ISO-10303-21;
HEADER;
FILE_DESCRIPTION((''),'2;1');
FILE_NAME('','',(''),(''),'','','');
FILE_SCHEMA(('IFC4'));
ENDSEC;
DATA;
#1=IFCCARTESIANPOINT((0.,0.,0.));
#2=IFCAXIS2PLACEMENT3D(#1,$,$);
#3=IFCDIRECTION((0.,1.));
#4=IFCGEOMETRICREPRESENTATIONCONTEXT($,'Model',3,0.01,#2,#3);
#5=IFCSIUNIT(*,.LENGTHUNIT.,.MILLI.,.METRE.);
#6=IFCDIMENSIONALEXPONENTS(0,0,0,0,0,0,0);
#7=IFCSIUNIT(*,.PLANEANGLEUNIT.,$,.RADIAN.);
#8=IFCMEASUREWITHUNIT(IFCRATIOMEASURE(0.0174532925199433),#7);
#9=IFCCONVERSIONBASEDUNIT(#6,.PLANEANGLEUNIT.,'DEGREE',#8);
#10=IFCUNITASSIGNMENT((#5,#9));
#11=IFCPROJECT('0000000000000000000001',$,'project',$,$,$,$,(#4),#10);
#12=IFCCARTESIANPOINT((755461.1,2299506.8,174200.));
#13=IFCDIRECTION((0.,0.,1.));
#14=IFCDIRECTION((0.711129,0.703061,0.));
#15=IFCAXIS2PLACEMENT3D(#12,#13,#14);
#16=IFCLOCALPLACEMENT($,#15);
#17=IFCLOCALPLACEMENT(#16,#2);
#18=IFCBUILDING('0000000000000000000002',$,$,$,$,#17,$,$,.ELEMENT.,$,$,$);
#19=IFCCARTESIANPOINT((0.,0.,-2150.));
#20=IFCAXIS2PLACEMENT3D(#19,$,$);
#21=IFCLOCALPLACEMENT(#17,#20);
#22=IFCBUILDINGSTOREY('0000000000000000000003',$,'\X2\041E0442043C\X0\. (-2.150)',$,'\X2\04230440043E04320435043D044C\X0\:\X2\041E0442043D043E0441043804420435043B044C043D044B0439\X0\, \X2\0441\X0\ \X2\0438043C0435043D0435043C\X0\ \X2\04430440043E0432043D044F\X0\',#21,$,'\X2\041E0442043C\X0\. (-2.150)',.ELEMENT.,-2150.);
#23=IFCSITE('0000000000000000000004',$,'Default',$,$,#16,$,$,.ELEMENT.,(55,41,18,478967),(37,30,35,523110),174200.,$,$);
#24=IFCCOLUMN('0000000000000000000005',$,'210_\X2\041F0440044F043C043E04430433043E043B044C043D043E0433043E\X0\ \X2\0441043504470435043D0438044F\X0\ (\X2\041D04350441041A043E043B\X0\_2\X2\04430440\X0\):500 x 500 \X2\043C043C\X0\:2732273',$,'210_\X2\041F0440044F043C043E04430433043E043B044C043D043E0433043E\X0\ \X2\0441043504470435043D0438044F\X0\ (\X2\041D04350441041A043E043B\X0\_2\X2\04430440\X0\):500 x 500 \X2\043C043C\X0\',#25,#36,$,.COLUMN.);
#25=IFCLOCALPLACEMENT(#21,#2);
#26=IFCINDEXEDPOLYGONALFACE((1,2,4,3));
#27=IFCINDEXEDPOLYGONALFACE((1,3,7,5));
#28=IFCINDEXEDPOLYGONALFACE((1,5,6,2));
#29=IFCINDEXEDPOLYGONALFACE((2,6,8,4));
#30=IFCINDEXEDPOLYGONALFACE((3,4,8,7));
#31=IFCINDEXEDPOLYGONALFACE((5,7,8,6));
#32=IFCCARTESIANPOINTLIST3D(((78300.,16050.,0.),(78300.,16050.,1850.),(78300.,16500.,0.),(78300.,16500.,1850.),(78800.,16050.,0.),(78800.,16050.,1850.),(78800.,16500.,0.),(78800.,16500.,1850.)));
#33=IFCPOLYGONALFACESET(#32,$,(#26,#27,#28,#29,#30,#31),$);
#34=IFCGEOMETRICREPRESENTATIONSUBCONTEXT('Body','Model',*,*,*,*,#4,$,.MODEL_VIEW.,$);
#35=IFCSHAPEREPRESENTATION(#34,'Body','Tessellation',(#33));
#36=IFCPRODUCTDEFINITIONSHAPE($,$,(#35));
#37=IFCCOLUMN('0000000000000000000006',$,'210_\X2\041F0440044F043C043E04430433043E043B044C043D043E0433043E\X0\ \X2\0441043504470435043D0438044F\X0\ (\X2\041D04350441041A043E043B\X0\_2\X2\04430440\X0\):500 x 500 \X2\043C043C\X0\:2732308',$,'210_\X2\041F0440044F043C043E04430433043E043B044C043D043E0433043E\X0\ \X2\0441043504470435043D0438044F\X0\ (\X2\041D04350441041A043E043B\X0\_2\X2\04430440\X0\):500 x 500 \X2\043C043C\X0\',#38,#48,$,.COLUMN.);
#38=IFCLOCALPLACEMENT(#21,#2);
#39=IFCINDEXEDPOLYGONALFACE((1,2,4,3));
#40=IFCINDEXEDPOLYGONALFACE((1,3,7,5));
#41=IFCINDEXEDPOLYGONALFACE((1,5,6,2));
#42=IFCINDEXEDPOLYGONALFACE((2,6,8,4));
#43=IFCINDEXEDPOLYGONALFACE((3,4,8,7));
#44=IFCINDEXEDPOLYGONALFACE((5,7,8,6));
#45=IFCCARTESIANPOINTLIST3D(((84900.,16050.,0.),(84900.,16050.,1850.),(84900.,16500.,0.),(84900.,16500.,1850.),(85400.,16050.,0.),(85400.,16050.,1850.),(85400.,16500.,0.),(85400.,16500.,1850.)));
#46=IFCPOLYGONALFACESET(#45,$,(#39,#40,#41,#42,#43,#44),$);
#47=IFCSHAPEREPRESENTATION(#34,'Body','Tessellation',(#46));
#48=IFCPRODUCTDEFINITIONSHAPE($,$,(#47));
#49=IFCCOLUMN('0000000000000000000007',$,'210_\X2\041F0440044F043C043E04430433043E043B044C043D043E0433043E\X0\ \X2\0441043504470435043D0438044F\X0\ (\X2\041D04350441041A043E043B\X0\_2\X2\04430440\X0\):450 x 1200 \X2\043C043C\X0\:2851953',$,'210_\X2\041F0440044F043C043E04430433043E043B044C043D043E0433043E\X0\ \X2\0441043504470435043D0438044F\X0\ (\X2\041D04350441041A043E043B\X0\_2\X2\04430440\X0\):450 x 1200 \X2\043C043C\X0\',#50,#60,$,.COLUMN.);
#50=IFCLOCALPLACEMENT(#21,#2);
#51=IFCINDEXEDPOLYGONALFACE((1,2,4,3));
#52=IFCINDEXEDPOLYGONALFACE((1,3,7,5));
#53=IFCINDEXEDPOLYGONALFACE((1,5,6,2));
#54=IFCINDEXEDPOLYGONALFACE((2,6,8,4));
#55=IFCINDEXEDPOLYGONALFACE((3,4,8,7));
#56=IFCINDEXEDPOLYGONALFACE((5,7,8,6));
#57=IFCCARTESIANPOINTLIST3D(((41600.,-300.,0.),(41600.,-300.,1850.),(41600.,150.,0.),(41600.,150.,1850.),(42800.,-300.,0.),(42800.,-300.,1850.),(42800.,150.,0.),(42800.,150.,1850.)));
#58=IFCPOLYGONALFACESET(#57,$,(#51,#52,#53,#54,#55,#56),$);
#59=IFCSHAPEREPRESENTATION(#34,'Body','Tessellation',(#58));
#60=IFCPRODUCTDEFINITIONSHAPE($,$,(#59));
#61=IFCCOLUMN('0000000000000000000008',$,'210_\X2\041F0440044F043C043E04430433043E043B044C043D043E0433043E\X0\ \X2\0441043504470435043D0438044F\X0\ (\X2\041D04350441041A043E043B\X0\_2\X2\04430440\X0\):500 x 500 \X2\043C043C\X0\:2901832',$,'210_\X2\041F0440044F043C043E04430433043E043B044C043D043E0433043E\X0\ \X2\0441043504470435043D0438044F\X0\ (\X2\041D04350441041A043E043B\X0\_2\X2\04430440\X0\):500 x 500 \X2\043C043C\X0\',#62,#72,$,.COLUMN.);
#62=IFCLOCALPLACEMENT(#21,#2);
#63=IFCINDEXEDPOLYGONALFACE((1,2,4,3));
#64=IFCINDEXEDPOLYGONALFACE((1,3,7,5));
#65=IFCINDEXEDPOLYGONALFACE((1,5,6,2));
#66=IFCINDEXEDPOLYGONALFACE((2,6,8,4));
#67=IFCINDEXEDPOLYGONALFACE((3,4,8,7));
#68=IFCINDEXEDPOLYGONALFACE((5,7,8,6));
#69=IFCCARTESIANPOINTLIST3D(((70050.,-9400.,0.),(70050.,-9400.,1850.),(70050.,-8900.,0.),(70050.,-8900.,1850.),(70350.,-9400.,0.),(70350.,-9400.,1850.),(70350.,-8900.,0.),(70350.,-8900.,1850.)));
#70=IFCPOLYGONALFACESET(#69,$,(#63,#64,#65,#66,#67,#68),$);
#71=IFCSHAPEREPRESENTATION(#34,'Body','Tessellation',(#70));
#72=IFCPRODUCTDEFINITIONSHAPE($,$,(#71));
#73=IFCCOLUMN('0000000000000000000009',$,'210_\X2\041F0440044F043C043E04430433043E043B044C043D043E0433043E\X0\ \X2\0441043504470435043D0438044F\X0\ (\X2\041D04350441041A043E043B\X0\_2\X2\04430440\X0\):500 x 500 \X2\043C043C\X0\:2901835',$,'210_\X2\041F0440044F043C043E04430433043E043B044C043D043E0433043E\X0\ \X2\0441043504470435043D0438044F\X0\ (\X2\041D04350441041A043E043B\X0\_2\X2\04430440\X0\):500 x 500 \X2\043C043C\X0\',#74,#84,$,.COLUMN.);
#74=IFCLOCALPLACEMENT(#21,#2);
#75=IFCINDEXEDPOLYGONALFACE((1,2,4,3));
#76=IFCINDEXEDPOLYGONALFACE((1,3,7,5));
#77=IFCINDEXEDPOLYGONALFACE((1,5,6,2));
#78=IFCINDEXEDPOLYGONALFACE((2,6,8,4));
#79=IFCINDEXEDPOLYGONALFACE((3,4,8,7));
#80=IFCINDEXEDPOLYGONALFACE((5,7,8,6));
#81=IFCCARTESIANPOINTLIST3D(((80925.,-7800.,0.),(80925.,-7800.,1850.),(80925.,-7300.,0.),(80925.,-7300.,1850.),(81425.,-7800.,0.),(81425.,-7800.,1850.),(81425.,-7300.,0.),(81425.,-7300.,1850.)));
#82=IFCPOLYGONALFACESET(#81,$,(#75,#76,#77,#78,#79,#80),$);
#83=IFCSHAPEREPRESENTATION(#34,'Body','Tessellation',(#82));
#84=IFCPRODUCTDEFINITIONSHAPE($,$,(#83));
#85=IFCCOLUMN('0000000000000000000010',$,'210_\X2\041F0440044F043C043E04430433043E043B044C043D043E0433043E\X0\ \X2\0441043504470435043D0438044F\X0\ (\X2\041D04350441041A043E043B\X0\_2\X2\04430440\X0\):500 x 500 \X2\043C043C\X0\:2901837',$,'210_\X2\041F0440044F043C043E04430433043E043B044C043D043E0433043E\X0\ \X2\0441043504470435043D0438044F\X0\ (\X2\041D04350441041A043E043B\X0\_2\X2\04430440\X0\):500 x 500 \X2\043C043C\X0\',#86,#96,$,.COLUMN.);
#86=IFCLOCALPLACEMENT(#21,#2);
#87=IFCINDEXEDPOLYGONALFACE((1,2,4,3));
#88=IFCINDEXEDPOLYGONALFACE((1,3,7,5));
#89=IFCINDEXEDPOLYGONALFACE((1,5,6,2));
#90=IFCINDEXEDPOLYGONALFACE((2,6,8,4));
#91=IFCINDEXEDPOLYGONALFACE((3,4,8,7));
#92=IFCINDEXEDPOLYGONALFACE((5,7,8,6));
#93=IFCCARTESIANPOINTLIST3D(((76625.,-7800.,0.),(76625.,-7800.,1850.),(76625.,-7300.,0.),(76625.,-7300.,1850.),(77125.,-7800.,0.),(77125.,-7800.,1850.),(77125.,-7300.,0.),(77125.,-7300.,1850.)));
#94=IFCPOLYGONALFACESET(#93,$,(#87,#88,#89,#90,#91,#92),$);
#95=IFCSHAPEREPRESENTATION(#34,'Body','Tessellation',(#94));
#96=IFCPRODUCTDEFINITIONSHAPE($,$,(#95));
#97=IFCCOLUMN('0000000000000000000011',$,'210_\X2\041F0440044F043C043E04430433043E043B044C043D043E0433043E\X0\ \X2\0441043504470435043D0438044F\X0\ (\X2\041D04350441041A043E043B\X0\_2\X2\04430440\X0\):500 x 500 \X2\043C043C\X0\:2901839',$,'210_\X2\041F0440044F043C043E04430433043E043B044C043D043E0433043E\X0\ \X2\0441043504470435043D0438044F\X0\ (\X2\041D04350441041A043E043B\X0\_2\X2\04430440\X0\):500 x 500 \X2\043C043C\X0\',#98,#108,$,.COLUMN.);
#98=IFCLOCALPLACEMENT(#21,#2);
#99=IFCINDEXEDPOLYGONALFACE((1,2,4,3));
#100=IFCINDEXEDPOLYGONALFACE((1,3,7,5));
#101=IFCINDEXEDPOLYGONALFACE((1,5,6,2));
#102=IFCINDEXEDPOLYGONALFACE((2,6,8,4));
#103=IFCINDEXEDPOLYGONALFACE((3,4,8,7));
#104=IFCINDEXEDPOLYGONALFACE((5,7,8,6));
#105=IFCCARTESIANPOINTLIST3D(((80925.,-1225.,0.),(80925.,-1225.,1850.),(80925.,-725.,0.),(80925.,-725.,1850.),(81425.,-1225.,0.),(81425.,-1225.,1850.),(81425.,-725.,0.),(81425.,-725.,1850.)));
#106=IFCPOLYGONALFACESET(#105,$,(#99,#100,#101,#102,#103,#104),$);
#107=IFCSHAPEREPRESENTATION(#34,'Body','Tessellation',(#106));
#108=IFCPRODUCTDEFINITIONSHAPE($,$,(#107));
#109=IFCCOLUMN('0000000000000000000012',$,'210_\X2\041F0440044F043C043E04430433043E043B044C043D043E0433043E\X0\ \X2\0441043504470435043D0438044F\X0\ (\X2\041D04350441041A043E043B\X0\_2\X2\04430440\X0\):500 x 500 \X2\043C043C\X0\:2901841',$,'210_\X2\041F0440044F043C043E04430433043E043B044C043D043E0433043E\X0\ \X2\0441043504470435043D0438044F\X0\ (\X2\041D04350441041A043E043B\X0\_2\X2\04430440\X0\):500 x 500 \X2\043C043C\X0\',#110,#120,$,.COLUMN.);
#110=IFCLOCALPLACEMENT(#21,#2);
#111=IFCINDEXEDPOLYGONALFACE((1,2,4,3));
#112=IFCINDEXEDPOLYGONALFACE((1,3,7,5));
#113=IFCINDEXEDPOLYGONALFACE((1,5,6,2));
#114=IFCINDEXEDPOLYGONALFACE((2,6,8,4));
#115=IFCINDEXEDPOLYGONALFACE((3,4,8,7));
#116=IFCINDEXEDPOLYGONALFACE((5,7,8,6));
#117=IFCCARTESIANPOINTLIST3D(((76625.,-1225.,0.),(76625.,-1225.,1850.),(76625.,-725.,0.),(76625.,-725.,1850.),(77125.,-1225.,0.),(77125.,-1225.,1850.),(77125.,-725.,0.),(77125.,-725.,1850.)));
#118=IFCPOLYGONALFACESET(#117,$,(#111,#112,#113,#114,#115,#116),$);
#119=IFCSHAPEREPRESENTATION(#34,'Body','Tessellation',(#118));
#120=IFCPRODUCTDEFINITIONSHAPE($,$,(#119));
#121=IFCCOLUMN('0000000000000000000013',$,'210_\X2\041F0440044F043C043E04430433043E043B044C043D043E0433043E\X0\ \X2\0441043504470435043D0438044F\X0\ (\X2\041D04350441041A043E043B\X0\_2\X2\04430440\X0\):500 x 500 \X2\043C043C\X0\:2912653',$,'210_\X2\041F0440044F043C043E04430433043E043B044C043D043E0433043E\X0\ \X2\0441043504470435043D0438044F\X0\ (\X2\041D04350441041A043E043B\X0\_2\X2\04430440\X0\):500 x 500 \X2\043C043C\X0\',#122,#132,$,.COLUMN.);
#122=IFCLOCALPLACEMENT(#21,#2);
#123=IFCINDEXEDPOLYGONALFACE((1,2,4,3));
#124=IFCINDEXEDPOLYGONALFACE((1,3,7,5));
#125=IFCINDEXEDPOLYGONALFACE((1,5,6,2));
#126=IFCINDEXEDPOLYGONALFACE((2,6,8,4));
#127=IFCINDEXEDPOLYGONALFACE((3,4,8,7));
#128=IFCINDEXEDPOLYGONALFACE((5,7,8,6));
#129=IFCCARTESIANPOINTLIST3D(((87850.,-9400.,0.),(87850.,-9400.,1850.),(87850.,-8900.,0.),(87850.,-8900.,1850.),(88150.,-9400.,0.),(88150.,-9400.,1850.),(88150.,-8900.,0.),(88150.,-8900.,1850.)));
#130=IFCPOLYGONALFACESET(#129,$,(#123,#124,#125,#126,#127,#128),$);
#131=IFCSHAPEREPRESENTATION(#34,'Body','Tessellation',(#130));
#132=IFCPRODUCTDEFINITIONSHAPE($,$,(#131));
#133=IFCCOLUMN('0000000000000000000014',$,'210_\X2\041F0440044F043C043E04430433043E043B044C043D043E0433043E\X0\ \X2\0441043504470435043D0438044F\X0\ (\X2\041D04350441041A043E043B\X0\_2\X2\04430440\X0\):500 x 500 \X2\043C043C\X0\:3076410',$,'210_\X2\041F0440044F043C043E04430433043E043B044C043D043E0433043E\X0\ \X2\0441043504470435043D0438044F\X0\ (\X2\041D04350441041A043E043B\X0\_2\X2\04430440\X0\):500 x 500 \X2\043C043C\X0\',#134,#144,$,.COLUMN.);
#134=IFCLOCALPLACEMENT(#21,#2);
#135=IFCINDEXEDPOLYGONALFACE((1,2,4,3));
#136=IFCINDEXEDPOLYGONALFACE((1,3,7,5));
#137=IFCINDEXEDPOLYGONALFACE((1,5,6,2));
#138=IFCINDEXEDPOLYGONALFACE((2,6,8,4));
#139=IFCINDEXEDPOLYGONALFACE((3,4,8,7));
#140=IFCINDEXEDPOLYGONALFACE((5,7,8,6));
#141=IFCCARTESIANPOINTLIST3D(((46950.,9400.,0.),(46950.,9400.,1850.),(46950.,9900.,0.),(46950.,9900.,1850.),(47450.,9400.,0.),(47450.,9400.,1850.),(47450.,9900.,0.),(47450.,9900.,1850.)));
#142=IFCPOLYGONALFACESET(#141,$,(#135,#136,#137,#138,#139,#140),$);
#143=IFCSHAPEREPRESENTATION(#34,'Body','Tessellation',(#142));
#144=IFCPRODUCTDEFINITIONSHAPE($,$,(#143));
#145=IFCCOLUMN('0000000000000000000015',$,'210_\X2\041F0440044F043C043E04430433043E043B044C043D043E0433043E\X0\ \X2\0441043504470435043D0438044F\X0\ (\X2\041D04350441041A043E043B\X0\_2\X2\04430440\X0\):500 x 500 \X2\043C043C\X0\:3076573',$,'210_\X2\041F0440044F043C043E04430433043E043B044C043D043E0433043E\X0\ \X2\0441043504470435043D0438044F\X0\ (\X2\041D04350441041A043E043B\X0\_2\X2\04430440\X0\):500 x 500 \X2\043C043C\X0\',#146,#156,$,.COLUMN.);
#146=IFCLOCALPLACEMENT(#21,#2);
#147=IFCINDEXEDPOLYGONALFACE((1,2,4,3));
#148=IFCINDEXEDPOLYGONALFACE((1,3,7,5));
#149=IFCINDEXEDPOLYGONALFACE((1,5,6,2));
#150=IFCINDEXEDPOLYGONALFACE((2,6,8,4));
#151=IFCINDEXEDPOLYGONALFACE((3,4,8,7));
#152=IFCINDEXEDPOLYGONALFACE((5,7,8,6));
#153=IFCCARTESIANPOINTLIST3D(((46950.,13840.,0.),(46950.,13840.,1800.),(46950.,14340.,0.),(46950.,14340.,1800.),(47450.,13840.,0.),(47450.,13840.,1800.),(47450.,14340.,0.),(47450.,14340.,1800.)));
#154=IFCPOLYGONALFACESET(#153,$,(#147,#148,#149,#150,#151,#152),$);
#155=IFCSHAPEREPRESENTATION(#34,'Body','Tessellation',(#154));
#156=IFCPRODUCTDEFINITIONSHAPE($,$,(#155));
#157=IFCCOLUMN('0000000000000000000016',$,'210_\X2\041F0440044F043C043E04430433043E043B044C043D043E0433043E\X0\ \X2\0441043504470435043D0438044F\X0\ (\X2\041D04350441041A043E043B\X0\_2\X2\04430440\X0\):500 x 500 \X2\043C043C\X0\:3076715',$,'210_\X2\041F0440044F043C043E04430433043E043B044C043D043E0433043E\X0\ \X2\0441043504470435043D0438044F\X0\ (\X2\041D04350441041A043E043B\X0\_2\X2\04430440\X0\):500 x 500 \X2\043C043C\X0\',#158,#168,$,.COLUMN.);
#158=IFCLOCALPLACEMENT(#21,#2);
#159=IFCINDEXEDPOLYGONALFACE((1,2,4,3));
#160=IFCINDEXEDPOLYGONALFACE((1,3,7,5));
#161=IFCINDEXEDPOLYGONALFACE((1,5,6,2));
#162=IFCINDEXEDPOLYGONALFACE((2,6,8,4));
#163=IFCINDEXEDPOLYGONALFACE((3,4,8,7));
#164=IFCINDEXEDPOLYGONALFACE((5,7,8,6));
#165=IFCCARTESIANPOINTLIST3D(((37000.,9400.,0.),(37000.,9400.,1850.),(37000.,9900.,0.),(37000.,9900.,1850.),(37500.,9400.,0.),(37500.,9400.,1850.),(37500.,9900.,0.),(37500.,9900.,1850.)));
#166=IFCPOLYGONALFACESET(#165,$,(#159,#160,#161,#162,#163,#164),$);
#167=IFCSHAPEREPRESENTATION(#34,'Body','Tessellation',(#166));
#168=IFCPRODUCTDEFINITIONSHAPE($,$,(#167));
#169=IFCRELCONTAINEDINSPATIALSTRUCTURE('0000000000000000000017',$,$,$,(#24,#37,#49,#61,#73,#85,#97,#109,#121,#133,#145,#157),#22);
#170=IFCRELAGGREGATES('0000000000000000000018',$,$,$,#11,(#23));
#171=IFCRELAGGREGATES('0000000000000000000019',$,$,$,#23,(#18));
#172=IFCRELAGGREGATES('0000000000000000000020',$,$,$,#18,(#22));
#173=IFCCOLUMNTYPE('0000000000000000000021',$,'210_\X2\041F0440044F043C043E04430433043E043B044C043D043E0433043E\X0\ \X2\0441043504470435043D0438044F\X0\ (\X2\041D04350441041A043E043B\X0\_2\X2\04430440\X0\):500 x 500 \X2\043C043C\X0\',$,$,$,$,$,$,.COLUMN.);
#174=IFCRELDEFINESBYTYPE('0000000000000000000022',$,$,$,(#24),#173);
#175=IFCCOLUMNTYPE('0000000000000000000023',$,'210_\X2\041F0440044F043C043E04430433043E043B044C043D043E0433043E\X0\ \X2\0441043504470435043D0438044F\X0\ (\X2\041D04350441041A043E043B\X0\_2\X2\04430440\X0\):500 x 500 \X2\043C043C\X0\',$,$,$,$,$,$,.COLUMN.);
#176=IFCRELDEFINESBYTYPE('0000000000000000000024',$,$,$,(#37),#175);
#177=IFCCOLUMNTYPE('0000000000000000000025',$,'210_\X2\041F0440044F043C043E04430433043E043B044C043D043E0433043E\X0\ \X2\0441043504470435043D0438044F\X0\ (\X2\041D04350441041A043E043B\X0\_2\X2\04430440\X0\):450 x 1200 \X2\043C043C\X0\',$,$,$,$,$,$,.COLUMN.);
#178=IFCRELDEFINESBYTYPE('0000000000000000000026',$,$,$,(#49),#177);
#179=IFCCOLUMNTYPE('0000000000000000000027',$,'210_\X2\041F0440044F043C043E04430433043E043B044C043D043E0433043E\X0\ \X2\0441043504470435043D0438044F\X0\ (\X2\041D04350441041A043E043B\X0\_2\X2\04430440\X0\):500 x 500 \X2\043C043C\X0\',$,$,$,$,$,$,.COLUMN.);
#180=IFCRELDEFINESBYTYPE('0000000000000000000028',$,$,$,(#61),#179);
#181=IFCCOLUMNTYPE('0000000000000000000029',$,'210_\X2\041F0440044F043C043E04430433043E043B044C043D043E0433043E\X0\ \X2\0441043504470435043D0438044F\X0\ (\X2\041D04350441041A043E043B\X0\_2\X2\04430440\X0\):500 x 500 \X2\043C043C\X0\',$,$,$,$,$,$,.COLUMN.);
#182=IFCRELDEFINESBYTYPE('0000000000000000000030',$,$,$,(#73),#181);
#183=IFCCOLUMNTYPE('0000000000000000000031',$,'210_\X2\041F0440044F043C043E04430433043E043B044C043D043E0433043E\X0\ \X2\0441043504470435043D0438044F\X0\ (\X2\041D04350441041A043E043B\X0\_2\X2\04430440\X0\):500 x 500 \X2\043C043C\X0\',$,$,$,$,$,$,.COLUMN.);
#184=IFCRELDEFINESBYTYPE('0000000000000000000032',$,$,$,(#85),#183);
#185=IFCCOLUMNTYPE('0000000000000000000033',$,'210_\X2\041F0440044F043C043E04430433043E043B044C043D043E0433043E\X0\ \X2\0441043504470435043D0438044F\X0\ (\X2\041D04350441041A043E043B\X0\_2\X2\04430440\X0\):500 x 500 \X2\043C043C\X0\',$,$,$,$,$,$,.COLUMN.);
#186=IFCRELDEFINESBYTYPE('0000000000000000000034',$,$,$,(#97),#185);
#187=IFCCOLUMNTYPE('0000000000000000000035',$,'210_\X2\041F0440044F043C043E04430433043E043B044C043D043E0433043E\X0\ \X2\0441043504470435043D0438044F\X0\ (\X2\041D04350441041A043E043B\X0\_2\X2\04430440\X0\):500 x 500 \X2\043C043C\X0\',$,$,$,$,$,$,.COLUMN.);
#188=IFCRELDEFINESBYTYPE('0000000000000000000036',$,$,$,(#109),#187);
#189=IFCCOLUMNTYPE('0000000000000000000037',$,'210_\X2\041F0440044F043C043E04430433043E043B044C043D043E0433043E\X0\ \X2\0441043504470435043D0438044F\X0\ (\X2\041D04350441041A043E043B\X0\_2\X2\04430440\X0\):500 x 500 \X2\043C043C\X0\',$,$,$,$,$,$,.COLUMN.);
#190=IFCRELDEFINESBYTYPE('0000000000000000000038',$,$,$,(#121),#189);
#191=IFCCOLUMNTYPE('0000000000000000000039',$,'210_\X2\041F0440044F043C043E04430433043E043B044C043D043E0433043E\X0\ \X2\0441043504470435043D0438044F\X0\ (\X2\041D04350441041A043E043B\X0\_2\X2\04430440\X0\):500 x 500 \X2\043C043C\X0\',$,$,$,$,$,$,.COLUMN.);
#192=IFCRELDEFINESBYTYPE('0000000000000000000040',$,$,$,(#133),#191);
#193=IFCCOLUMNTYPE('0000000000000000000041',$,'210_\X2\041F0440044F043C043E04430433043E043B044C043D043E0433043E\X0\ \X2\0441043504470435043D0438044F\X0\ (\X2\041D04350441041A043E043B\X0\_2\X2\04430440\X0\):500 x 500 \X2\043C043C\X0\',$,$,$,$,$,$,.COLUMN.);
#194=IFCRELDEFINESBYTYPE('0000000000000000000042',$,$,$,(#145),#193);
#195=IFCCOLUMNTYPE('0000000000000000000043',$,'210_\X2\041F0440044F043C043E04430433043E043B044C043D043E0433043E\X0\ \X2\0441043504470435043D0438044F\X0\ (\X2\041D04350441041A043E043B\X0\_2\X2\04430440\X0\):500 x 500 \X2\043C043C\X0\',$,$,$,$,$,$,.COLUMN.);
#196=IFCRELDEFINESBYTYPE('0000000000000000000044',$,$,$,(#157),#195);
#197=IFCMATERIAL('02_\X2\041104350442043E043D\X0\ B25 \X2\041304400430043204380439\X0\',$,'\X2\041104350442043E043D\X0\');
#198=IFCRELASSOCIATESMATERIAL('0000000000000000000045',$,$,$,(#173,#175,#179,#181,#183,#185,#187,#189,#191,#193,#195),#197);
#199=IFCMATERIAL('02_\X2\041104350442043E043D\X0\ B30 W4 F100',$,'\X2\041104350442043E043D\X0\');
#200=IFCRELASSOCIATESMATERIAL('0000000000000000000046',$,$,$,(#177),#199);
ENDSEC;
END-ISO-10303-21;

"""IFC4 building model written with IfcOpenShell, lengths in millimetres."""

from ifc_helpers import new_model, entity, si_unit, converted_unit, direction, frame, origin, place, context, subcontext, project, spatial, indexed_curve, outline, extrude, source, transform, mapped, material, type_object, type_shapes, element, save


model = new_model("IFC4")

# Units and contexts
model_context = context("Model", 3, precision=0.01, world=origin(), true_north=direction((0.0, 1.0)))
body_context = subcontext(model_context, "Body", "Model", "MODEL_VIEW")
ifc_project = project(units=[si_unit("LENGTHUNIT", "METRE", prefix="MILLI"), converted_unit("PLANEANGLEUNIT", "DEGREE", entity("IfcRatioMeasure", 0.0174532925199433), si_unit("PLANEANGLEUNIT", "RADIAN"), dimensions=[0, 0, 0, 0, 0, 0, 0])], contexts=[model_context])

# Site, building, storey
site_placement = place(None, frame((755461.1, 2299506.8, 174200.0), z_axis=(0.0, 0.0, 1.0), x_axis=(0.711129, 0.703061, 0.0)))
site = spatial("IfcSite", under=ifc_project, at=site_placement, Name="Default", CompositionType="ELEMENT", RefLatitude=(55, 41, 18, 478967), RefLongitude=(37, 30, 35, 523110), RefElevation=174200.0)
building_placement = place(site_placement, origin())
building = spatial("IfcBuilding", under=site, at=building_placement, CompositionType="ELEMENT")
storey_placement = place(building_placement, frame((0.0, 0.0, -2150.0)))
storey = spatial("IfcBuildingStorey", under=building, at=storey_placement, Name="Отм. (-2.150)", ObjectType="Уровень:Относительный, с именем уровня", LongName="Отм. (-2.150)", CompositionType="ELEMENT", Elevation=-2150.0)

# Columns
ifc_material_1 = material(Name="02_Бетон B25 Гравий", Category="Бетон")
column_type_1 = type_object("IfcColumnType", Name="210_Прямоугольного сечения (НесКол_2ур):500 x 500 мм", PredefinedType="COLUMN", material=ifc_material_1)
shared_shape_1 = source(origin(), body_context, "Body", "SweptSolid", [
    extrude(outline(indexed_curve([(-225.0, -250.0), (225.0, -250.0), (225.0, 250.0), (-225.0, 250.0), (-225.0, -250.0)], self_intersect=False)), frame((78550.0, 16275.0, -2150.0), z_axis=(0.0, 0.0, 1.0), x_axis=(0.0, -1.0, 0.0)), (0.0, 0.0, 1.0), 1850.0),
])
type_shapes(column_type_1, [shared_shape_1])
column_1_placement = place(storey_placement, frame((0.0, 0.0, 2150.0)))
element("IfcColumn", 1, at=column_1_placement, inside=storey, type_object=column_type_1, Name="210_Прямоугольного сечения (НесКол_2ур):500 x 500 мм:2732273", ObjectType="210_Прямоугольного сечения (НесКол_2ур):500 x 500 мм", PredefinedType="COLUMN", context=body_context, shape_type="MappedRepresentation", body=[
    mapped(shared_shape_1, transform((0.0, 0.0, 0.0), scale=1.0)),
])
column_type_2 = type_object("IfcColumnType", Name="210_Прямоугольного сечения (НесКол_2ур):500 x 500 мм", PredefinedType="COLUMN", material=ifc_material_1)
shared_shape_2 = source(origin(), body_context, "Body", "SweptSolid", [
    extrude(outline(indexed_curve([(-225.0, -250.0), (225.0, -250.0), (225.0, 250.0), (-225.0, 250.0), (-225.0, -250.0)], self_intersect=False)), frame((85150.0, 16275.0, -2150.0), z_axis=(0.0, 0.0, 1.0), x_axis=(0.0, -1.0, 0.0)), (0.0, 0.0, 1.0), 1850.0),
])
type_shapes(column_type_2, [shared_shape_2])
column_2_placement = place(storey_placement, frame((0.0, 0.0, 2150.0)))
element("IfcColumn", 2, at=column_2_placement, inside=storey, type_object=column_type_2, Name="210_Прямоугольного сечения (НесКол_2ур):500 x 500 мм:2732308", ObjectType="210_Прямоугольного сечения (НесКол_2ур):500 x 500 мм", PredefinedType="COLUMN", context=body_context, shape_type="MappedRepresentation", body=[
    mapped(shared_shape_2, transform((0.0, 0.0, 0.0), scale=1.0)),
])
ifc_material_2 = material(Name="02_Бетон B30 W4 F100", Category="Бетон")
column_type_3 = type_object("IfcColumnType", Name="210_Прямоугольного сечения (НесКол_2ур):450 x 1200 мм", PredefinedType="COLUMN", material=ifc_material_2)
shared_shape_3 = source(origin(), body_context, "Body", "SweptSolid", [
    extrude(outline(indexed_curve([(-225.0, -600.0), (225.0, -600.0), (225.0, 600.0), (-225.0, 600.0), (-225.0, -600.0)], self_intersect=False)), frame((42200.0, -75.0, -2150.0), z_axis=(0.0, 0.0, 1.0), x_axis=(0.0, -1.0, 0.0)), (0.0, 0.0, 1.0), 1850.0),
])
type_shapes(column_type_3, [shared_shape_3])
column_3_placement = place(storey_placement, frame((0.0, 0.0, 2150.0)))
element("IfcColumn", 3, at=column_3_placement, inside=storey, type_object=column_type_3, Name="210_Прямоугольного сечения (НесКол_2ур):450 x 1200 мм:2851953", ObjectType="210_Прямоугольного сечения (НесКол_2ур):450 x 1200 мм", PredefinedType="COLUMN", context=body_context, shape_type="MappedRepresentation", body=[
    mapped(shared_shape_3, transform((0.0, 0.0, 0.0), scale=1.0)),
])
column_type_4 = type_object("IfcColumnType", Name="210_Прямоугольного сечения (НесКол_2ур):500 x 500 мм", PredefinedType="COLUMN", material=ifc_material_1)
shared_shape_4 = source(origin(), body_context, "Body", "SweptSolid", [
    extrude(outline(indexed_curve([(-250.0, -150.0), (250.0, -150.0), (250.0, 150.0), (-250.0, 150.0), (-250.0, -150.0)], self_intersect=False)), frame((70200.0, -9150.0, -2150.0), z_axis=(0.0, 0.0, 1.0), x_axis=(0.0, -1.0, 0.0)), (0.0, 0.0, 1.0), 1850.0),
])
type_shapes(column_type_4, [shared_shape_4])
column_4_placement = place(storey_placement, frame((0.0, 0.0, 2150.0)))
element("IfcColumn", 4, at=column_4_placement, inside=storey, type_object=column_type_4, Name="210_Прямоугольного сечения (НесКол_2ур):500 x 500 мм:2901832", ObjectType="210_Прямоугольного сечения (НесКол_2ур):500 x 500 мм", PredefinedType="COLUMN", context=body_context, shape_type="MappedRepresentation", body=[
    mapped(shared_shape_4, transform((0.0, 0.0, 0.0), scale=1.0)),
])
column_type_5 = type_object("IfcColumnType", Name="210_Прямоугольного сечения (НесКол_2ур):500 x 500 мм", PredefinedType="COLUMN", material=ifc_material_1)
shared_shape_5 = source(origin(), body_context, "Body", "SweptSolid", [
    extrude(outline(indexed_curve([(-250.0, -250.0), (250.0, -250.0), (250.0, 250.0), (-250.0, 250.0), (-250.0, -250.0)], self_intersect=False)), frame((81175.0, -7550.0, -2150.0), z_axis=(0.0, 0.0, 1.0), x_axis=(0.0, -1.0, 0.0)), (0.0, 0.0, 1.0), 1850.0),
])
type_shapes(column_type_5, [shared_shape_5])
column_5_placement = place(storey_placement, frame((0.0, 0.0, 2150.0)))
element("IfcColumn", 5, at=column_5_placement, inside=storey, type_object=column_type_5, Name="210_Прямоугольного сечения (НесКол_2ур):500 x 500 мм:2901835", ObjectType="210_Прямоугольного сечения (НесКол_2ур):500 x 500 мм", PredefinedType="COLUMN", context=body_context, shape_type="MappedRepresentation", body=[
    mapped(shared_shape_5, transform((0.0, 0.0, 0.0), scale=1.0)),
])
column_type_6 = type_object("IfcColumnType", Name="210_Прямоугольного сечения (НесКол_2ур):500 x 500 мм", PredefinedType="COLUMN", material=ifc_material_1)
shared_shape_6 = source(origin(), body_context, "Body", "SweptSolid", [
    extrude(outline(indexed_curve([(-250.0, -250.0), (250.0, -250.0), (250.0, 250.0), (-250.0, 250.0), (-250.0, -250.0)], self_intersect=False)), frame((76875.0, -7550.0, -2150.0), z_axis=(0.0, 0.0, 1.0), x_axis=(0.0, -1.0, 0.0)), (0.0, 0.0, 1.0), 1850.0),
])
type_shapes(column_type_6, [shared_shape_6])
column_6_placement = place(storey_placement, frame((0.0, 0.0, 2150.0)))
element("IfcColumn", 6, at=column_6_placement, inside=storey, type_object=column_type_6, Name="210_Прямоугольного сечения (НесКол_2ур):500 x 500 мм:2901837", ObjectType="210_Прямоугольного сечения (НесКол_2ур):500 x 500 мм", PredefinedType="COLUMN", context=body_context, shape_type="MappedRepresentation", body=[
    mapped(shared_shape_6, transform((0.0, 0.0, 0.0), scale=1.0)),
])
column_type_7 = type_object("IfcColumnType", Name="210_Прямоугольного сечения (НесКол_2ур):500 x 500 мм", PredefinedType="COLUMN", material=ifc_material_1)
shared_shape_7 = source(origin(), body_context, "Body", "SweptSolid", [
    extrude(outline(indexed_curve([(-250.0, -250.0), (250.0, -250.0), (250.0, 250.0), (-250.0, 250.0), (-250.0, -250.0)], self_intersect=False)), frame((81175.0, -975.0, -2150.0), z_axis=(0.0, 0.0, 1.0), x_axis=(0.0, -1.0, 0.0)), (0.0, 0.0, 1.0), 1850.0),
])
type_shapes(column_type_7, [shared_shape_7])
column_7_placement = place(storey_placement, frame((0.0, 0.0, 2150.0)))
element("IfcColumn", 7, at=column_7_placement, inside=storey, type_object=column_type_7, Name="210_Прямоугольного сечения (НесКол_2ур):500 x 500 мм:2901839", ObjectType="210_Прямоугольного сечения (НесКол_2ур):500 x 500 мм", PredefinedType="COLUMN", context=body_context, shape_type="MappedRepresentation", body=[
    mapped(shared_shape_7, transform((0.0, 0.0, 0.0), scale=1.0)),
])
column_type_8 = type_object("IfcColumnType", Name="210_Прямоугольного сечения (НесКол_2ур):500 x 500 мм", PredefinedType="COLUMN", material=ifc_material_1)
shared_shape_8 = source(origin(), body_context, "Body", "SweptSolid", [
    extrude(outline(indexed_curve([(-250.0, -250.0), (250.0, -250.0), (250.0, 250.0), (-250.0, 250.0), (-250.0, -250.0)], self_intersect=False)), frame((76875.0, -975.0, -2150.0), z_axis=(0.0, 0.0, 1.0), x_axis=(0.0, -1.0, 0.0)), (0.0, 0.0, 1.0), 1850.0),
])
type_shapes(column_type_8, [shared_shape_8])
column_8_placement = place(storey_placement, frame((0.0, 0.0, 2150.0)))
element("IfcColumn", 8, at=column_8_placement, inside=storey, type_object=column_type_8, Name="210_Прямоугольного сечения (НесКол_2ур):500 x 500 мм:2901841", ObjectType="210_Прямоугольного сечения (НесКол_2ур):500 x 500 мм", PredefinedType="COLUMN", context=body_context, shape_type="MappedRepresentation", body=[
    mapped(shared_shape_8, transform((0.0, 0.0, 0.0), scale=1.0)),
])
column_type_9 = type_object("IfcColumnType", Name="210_Прямоугольного сечения (НесКол_2ур):500 x 500 мм", PredefinedType="COLUMN", material=ifc_material_1)
shared_shape_9 = source(origin(), body_context, "Body", "SweptSolid", [
    extrude(outline(indexed_curve([(-250.0, -150.0), (250.0, -150.0), (250.0, 150.0), (-250.0, 150.0), (-250.0, -150.0)], self_intersect=False)), frame((88000.0, -9150.0, -2150.0), z_axis=(0.0, 0.0, 1.0), x_axis=(0.0, -1.0, 0.0)), (0.0, 0.0, 1.0), 1850.0),
])
type_shapes(column_type_9, [shared_shape_9])
column_9_placement = place(storey_placement, frame((0.0, 0.0, 2150.0)))
element("IfcColumn", 9, at=column_9_placement, inside=storey, type_object=column_type_9, Name="210_Прямоугольного сечения (НесКол_2ур):500 x 500 мм:2912653", ObjectType="210_Прямоугольного сечения (НесКол_2ур):500 x 500 мм", PredefinedType="COLUMN", context=body_context, shape_type="MappedRepresentation", body=[
    mapped(shared_shape_9, transform((0.0, 0.0, 0.0), scale=1.0)),
])
column_type_10 = type_object("IfcColumnType", Name="210_Прямоугольного сечения (НесКол_2ур):500 x 500 мм", PredefinedType="COLUMN", material=ifc_material_1)
shared_shape_10 = source(origin(), body_context, "Body", "SweptSolid", [
    extrude(outline(indexed_curve([(-250.0, -250.0), (250.0, -250.0), (250.0, 250.0), (-250.0, 250.0), (-250.0, -250.0)], self_intersect=False)), frame((47200.0, 9650.0, -2150.0), z_axis=(0.0, 0.0, 1.0), x_axis=(0.0, -1.0, 0.0)), (0.0, 0.0, 1.0), 1850.0),
])
type_shapes(column_type_10, [shared_shape_10])
column_10_placement = place(storey_placement, frame((0.0, 0.0, 2150.0)))
element("IfcColumn", 10, at=column_10_placement, inside=storey, type_object=column_type_10, Name="210_Прямоугольного сечения (НесКол_2ур):500 x 500 мм:3076410", ObjectType="210_Прямоугольного сечения (НесКол_2ур):500 x 500 мм", PredefinedType="COLUMN", context=body_context, shape_type="MappedRepresentation", body=[
    mapped(shared_shape_10, transform((0.0, 0.0, 0.0), scale=1.0)),
])
column_type_11 = type_object("IfcColumnType", Name="210_Прямоугольного сечения (НесКол_2ур):500 x 500 мм", PredefinedType="COLUMN", material=ifc_material_1)
shared_shape_11 = source(origin(), body_context, "Body", "SweptSolid", [
    extrude(outline(indexed_curve([(-250.0, -250.0), (250.0, -250.0), (250.0, 250.0), (-250.0, 250.0), (-250.0, -250.0)], self_intersect=False)), frame((47200.0, 14090.0, -2150.0), z_axis=(0.0, 0.0, 1.0), x_axis=(0.0, -1.0, 0.0)), (0.0, 0.0, 1.0), 1800.0),
])
type_shapes(column_type_11, [shared_shape_11])
column_11_placement = place(storey_placement, frame((0.0, 0.0, 2150.0)))
element("IfcColumn", 11, at=column_11_placement, inside=storey, type_object=column_type_11, Name="210_Прямоугольного сечения (НесКол_2ур):500 x 500 мм:3076573", ObjectType="210_Прямоугольного сечения (НесКол_2ур):500 x 500 мм", PredefinedType="COLUMN", context=body_context, shape_type="MappedRepresentation", body=[
    mapped(shared_shape_11, transform((0.0, 0.0, 0.0), scale=1.0)),
])
column_type_12 = type_object("IfcColumnType", Name="210_Прямоугольного сечения (НесКол_2ур):500 x 500 мм", PredefinedType="COLUMN", material=ifc_material_1)
shared_shape_12 = source(origin(), body_context, "Body", "SweptSolid", [
    extrude(outline(indexed_curve([(-250.0, -250.0), (250.0, -250.0), (250.0, 250.0), (-250.0, 250.0), (-250.0, -250.0)], self_intersect=False)), frame((37250.0, 9650.0, -2150.0), z_axis=(0.0, 0.0, 1.0), x_axis=(0.0, -1.0, 0.0)), (0.0, 0.0, 1.0), 1850.0),
])
type_shapes(column_type_12, [shared_shape_12])
column_12_placement = place(storey_placement, frame((0.0, 0.0, 2150.0)))
element("IfcColumn", 12, at=column_12_placement, inside=storey, type_object=column_type_12, Name="210_Прямоугольного сечения (НесКол_2ур):500 x 500 мм:3076715", ObjectType="210_Прямоугольного сечения (НесКол_2ур):500 x 500 мм", PredefinedType="COLUMN", context=body_context, shape_type="MappedRepresentation", body=[
    mapped(shared_shape_12, transform((0.0, 0.0, 0.0), scale=1.0)),
])

save(model, "model.ifc")
